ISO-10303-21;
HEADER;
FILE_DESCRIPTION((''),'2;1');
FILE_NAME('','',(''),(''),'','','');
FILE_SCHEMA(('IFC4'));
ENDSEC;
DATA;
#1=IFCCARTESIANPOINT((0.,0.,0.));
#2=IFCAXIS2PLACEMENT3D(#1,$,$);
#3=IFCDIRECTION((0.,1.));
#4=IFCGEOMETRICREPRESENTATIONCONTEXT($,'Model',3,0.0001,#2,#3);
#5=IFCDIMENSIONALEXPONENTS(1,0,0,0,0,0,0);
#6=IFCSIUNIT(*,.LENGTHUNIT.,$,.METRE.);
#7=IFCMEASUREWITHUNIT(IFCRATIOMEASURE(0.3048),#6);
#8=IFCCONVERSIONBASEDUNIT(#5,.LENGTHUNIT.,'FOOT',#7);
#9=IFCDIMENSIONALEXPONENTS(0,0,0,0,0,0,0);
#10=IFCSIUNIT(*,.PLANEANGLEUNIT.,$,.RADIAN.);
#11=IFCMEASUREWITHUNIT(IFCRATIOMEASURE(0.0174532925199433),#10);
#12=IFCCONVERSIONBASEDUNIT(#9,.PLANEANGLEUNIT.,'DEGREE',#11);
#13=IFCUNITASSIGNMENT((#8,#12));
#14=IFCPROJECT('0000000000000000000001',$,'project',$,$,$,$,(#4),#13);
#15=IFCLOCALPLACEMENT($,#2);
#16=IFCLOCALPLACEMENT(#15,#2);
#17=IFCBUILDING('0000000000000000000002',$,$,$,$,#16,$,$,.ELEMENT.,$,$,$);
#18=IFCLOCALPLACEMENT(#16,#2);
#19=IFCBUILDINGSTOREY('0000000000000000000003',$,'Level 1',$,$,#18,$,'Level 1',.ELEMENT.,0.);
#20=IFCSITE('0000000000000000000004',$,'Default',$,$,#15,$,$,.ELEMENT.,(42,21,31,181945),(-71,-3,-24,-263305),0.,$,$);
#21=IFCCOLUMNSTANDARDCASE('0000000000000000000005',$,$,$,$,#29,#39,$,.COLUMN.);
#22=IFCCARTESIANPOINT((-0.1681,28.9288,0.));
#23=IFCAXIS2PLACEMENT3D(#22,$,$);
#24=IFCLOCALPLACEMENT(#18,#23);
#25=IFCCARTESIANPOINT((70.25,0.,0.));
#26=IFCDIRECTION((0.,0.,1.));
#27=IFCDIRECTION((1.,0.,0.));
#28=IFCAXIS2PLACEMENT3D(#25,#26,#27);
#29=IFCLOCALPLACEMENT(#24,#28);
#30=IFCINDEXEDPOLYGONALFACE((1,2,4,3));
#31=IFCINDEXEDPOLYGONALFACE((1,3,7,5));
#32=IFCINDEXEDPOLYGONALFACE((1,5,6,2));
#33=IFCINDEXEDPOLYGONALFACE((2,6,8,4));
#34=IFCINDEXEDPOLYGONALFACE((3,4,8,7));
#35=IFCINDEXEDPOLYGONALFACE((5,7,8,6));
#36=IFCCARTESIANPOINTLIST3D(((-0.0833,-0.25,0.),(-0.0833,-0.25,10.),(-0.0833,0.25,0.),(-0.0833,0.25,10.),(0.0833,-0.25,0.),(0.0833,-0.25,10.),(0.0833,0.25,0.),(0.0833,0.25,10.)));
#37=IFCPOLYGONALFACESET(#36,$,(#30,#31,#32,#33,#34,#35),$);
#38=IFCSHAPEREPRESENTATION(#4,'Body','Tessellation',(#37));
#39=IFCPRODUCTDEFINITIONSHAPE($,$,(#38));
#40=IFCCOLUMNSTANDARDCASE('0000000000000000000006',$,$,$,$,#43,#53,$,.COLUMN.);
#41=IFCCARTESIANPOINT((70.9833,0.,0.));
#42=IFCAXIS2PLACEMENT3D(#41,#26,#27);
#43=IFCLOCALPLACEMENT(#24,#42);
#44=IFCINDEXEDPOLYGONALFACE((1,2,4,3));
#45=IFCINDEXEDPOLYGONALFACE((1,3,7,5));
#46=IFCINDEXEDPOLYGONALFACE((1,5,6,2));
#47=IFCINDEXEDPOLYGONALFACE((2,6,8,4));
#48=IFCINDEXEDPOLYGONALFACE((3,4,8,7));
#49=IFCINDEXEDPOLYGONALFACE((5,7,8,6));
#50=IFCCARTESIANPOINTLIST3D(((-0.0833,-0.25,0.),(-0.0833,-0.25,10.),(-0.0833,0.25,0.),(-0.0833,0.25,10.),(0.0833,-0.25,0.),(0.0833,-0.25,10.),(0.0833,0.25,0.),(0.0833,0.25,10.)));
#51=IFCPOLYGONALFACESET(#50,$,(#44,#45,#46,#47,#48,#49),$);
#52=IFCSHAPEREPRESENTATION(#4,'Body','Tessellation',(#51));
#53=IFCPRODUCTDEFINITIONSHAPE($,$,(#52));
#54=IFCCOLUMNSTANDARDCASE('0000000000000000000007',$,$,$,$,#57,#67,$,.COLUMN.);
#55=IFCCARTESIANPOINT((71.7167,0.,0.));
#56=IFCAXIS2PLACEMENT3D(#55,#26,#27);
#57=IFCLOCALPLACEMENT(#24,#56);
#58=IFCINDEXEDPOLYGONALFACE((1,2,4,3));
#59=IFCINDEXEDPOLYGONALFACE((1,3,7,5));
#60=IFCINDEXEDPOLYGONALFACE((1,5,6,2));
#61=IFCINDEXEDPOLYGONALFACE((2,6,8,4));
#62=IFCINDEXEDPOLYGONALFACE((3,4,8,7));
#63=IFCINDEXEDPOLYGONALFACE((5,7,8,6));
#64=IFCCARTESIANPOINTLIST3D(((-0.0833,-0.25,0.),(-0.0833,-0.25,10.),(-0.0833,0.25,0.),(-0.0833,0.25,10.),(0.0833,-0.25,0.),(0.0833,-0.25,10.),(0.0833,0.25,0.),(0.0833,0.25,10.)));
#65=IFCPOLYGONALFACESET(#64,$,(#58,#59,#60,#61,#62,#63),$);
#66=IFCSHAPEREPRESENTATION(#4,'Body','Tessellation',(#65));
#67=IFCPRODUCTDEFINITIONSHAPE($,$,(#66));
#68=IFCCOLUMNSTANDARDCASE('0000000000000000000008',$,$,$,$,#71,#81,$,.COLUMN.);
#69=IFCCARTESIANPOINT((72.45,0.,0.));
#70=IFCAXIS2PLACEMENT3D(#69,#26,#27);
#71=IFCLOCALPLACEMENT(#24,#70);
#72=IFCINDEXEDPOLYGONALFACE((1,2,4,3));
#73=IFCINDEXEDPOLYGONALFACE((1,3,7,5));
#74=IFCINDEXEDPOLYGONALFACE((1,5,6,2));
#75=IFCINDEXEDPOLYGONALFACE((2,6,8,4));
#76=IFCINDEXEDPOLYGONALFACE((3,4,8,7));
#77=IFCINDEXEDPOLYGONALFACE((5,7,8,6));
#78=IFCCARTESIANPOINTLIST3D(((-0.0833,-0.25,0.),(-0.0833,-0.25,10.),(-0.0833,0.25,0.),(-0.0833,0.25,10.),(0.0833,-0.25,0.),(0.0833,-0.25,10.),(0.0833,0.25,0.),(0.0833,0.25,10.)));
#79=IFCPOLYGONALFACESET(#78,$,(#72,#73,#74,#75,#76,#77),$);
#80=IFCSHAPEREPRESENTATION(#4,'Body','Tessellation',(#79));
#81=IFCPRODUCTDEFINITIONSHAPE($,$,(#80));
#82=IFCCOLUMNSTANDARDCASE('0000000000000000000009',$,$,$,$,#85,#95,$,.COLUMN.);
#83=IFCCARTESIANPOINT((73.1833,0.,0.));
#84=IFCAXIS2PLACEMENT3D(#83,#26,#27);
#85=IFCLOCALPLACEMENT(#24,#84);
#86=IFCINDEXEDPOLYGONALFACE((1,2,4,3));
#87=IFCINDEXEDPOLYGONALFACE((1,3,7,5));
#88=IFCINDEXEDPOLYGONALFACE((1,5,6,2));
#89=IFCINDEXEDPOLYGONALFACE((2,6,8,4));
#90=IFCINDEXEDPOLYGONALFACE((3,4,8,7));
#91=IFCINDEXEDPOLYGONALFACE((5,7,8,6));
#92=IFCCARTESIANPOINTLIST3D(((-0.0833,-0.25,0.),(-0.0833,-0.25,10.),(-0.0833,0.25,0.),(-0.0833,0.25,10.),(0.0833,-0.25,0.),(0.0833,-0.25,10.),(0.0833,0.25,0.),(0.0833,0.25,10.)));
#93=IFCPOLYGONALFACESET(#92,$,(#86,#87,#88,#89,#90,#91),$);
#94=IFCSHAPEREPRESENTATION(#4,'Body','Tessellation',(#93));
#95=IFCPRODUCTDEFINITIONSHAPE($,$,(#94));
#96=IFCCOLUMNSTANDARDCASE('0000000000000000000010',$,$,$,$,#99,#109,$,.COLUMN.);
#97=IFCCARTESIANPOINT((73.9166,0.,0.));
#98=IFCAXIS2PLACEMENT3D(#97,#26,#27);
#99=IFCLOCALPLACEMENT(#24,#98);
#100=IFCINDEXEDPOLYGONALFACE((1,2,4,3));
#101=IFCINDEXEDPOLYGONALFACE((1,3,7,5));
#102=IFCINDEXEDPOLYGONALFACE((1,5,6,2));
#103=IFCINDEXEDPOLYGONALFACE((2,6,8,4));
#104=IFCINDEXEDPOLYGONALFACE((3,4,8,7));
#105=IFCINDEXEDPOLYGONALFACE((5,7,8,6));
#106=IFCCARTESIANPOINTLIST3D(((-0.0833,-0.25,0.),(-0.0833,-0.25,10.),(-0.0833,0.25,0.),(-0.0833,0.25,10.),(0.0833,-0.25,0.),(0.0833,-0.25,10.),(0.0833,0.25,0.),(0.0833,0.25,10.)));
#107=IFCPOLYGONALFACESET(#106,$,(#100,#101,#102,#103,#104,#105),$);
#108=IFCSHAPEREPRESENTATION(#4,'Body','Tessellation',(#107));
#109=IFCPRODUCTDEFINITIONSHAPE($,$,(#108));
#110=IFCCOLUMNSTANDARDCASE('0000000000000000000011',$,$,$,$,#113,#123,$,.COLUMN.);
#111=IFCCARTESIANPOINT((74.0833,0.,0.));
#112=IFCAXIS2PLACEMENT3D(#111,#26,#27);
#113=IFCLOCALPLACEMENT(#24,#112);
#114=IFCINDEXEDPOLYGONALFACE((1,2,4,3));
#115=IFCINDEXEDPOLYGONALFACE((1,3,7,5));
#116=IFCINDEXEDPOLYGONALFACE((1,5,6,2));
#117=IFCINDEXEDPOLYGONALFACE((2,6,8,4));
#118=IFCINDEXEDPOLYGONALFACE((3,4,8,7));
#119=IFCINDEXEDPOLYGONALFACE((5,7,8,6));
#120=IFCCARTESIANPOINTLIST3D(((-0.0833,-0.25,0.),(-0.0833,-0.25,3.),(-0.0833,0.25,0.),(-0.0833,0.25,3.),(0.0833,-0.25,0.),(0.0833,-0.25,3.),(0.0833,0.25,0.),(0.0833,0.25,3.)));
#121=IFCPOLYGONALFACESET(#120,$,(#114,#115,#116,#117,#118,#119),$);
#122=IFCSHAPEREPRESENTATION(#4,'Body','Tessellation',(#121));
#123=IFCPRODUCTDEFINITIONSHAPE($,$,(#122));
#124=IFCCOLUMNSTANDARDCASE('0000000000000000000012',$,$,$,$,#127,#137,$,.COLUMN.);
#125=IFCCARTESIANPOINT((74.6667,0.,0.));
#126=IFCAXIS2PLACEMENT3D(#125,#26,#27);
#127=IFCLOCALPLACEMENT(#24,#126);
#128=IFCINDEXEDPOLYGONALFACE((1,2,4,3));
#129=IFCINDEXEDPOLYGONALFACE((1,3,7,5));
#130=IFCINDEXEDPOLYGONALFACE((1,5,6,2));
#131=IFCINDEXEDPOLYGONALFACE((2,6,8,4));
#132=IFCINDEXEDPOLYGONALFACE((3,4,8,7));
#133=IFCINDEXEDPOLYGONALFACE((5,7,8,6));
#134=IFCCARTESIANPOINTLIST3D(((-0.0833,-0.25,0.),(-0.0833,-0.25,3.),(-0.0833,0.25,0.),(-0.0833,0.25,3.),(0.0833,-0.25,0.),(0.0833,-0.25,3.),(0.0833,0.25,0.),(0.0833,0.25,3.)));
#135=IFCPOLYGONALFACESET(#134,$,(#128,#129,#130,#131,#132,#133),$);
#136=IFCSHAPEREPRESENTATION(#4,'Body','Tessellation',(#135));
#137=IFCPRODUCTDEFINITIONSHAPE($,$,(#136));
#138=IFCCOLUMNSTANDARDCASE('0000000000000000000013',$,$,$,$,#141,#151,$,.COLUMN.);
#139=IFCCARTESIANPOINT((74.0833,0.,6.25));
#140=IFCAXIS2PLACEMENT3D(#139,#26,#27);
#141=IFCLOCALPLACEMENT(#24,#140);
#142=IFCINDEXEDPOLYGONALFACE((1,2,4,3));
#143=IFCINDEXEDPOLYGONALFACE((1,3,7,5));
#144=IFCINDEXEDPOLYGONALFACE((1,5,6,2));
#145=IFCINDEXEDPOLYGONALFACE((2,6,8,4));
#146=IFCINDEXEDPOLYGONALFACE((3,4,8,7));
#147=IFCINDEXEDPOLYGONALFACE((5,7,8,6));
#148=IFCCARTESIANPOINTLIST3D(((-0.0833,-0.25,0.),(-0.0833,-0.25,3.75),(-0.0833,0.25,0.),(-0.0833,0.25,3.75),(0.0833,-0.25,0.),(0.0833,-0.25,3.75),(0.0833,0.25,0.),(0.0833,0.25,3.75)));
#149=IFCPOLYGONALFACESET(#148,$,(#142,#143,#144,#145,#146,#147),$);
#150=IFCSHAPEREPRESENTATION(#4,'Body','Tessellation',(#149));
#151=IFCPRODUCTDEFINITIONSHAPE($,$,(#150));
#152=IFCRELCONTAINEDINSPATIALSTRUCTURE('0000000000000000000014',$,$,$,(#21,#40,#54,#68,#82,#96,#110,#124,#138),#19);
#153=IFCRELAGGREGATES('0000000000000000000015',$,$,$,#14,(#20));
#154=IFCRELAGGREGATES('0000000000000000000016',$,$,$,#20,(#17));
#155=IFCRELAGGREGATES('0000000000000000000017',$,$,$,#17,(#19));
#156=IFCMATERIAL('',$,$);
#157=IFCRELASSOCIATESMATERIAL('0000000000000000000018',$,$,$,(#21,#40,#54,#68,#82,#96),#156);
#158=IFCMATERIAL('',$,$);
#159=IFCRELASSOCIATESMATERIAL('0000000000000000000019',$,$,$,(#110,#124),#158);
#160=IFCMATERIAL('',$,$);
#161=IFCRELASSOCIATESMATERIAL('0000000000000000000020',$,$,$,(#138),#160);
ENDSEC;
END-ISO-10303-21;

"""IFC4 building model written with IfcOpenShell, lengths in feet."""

from ifc_helpers import new_model, entity, si_unit, converted_unit, direction, frame, origin, place, context, project, spatial, rectangle, extrude, material, element, save


model = new_model("IFC4")

# Units and contexts
model_context = context("Model", 3, precision=0.0001, world=origin(), true_north=direction((0.0, 1.0)))
ifc_project = project(units=[converted_unit("LENGTHUNIT", "FOOT", entity("IfcRatioMeasure", 0.3048), si_unit("LENGTHUNIT", "METRE"), dimensions=[1, 0, 0, 0, 0, 0, 0]), converted_unit("PLANEANGLEUNIT", "DEGREE", entity("IfcRatioMeasure", 0.0174532925199433), si_unit("PLANEANGLEUNIT", "RADIAN"), dimensions=[0, 0, 0, 0, 0, 0, 0])], contexts=[model_context])

# Site, building, storey
site_placement = place(None, origin())
site = spatial("IfcSite", under=ifc_project, at=site_placement, Name="Default", CompositionType="ELEMENT", RefLatitude=(42, 21, 31, 181945), RefLongitude=(-71, -3, -24, -263305), RefElevation=0.0)
building_placement = place(site_placement, origin())
building = spatial("IfcBuilding", under=site, at=building_placement, CompositionType="ELEMENT")
storey_placement = place(building_placement, origin())
storey = spatial("IfcBuildingStorey", under=building, at=storey_placement, Name="Level 1", LongName="Level 1", CompositionType="ELEMENT", Elevation=0.0)

# Columns
ifc_material_1 = material(Name="")
placement = place(storey_placement, frame((-0.1681, 28.9288, 0.0)))
for number, where, z_axis, x_axis in (
    (1, (70.25, 0.0, 0.0), (0.0, 0.0, 1.0), (1.0, 0.0, 0.0)),
    (2, (70.9833, 0.0, 0.0), (0.0, 0.0, 1.0), (1.0, 0.0, 0.0)),
    (3, (71.7167, 0.0, 0.0), (0.0, 0.0, 1.0), (1.0, 0.0, 0.0)),
    (4, (72.45, 0.0, 0.0), (0.0, 0.0, 1.0), (1.0, 0.0, 0.0)),
    (5, (73.1833, 0.0, 0.0), (0.0, 0.0, 1.0), (1.0, 0.0, 0.0)),
    (6, (73.9166, 0.0, 0.0), (0.0, 0.0, 1.0), (1.0, 0.0, 0.0)),
):
    element("IfcColumnStandardCase", number, at=place(placement, frame(where, z_axis=z_axis, x_axis=x_axis)), inside=storey, material=ifc_material_1, PredefinedType="COLUMN", context=model_context, shape_type="SweptSolid", body=[
        extrude(rectangle(XDim=0.1667, YDim=0.5), origin(), (0.0, 0.0, 1.0), 10.0),
    ])
ifc_material_2 = material(Name="")
for number, where, z_axis, x_axis in (
    (7, (74.0833, 0.0, 0.0), (0.0, 0.0, 1.0), (1.0, 0.0, 0.0)),
    (8, (74.6667, 0.0, 0.0), (0.0, 0.0, 1.0), (1.0, 0.0, 0.0)),
):
    element("IfcColumnStandardCase", number, at=place(placement, frame(where, z_axis=z_axis, x_axis=x_axis)), inside=storey, material=ifc_material_2, PredefinedType="COLUMN", context=model_context, shape_type="SweptSolid", body=[
        extrude(rectangle(XDim=0.1667, YDim=0.5), origin(), (0.0, 0.0, 1.0), 3.0),
    ])
ifc_material_3 = material(Name="")
for number, where, z_axis, x_axis in (
    (9, (74.0833, 0.0, 6.25), (0.0, 0.0, 1.0), (1.0, 0.0, 0.0)),
):
    element("IfcColumnStandardCase", number, at=place(placement, frame(where, z_axis=z_axis, x_axis=x_axis)), inside=storey, material=ifc_material_3, PredefinedType="COLUMN", context=model_context, shape_type="SweptSolid", body=[
        extrude(rectangle(XDim=0.1667, YDim=0.5), origin(), (0.0, 0.0, 1.0), 3.75),
    ])

save(model, "model.ifc")
